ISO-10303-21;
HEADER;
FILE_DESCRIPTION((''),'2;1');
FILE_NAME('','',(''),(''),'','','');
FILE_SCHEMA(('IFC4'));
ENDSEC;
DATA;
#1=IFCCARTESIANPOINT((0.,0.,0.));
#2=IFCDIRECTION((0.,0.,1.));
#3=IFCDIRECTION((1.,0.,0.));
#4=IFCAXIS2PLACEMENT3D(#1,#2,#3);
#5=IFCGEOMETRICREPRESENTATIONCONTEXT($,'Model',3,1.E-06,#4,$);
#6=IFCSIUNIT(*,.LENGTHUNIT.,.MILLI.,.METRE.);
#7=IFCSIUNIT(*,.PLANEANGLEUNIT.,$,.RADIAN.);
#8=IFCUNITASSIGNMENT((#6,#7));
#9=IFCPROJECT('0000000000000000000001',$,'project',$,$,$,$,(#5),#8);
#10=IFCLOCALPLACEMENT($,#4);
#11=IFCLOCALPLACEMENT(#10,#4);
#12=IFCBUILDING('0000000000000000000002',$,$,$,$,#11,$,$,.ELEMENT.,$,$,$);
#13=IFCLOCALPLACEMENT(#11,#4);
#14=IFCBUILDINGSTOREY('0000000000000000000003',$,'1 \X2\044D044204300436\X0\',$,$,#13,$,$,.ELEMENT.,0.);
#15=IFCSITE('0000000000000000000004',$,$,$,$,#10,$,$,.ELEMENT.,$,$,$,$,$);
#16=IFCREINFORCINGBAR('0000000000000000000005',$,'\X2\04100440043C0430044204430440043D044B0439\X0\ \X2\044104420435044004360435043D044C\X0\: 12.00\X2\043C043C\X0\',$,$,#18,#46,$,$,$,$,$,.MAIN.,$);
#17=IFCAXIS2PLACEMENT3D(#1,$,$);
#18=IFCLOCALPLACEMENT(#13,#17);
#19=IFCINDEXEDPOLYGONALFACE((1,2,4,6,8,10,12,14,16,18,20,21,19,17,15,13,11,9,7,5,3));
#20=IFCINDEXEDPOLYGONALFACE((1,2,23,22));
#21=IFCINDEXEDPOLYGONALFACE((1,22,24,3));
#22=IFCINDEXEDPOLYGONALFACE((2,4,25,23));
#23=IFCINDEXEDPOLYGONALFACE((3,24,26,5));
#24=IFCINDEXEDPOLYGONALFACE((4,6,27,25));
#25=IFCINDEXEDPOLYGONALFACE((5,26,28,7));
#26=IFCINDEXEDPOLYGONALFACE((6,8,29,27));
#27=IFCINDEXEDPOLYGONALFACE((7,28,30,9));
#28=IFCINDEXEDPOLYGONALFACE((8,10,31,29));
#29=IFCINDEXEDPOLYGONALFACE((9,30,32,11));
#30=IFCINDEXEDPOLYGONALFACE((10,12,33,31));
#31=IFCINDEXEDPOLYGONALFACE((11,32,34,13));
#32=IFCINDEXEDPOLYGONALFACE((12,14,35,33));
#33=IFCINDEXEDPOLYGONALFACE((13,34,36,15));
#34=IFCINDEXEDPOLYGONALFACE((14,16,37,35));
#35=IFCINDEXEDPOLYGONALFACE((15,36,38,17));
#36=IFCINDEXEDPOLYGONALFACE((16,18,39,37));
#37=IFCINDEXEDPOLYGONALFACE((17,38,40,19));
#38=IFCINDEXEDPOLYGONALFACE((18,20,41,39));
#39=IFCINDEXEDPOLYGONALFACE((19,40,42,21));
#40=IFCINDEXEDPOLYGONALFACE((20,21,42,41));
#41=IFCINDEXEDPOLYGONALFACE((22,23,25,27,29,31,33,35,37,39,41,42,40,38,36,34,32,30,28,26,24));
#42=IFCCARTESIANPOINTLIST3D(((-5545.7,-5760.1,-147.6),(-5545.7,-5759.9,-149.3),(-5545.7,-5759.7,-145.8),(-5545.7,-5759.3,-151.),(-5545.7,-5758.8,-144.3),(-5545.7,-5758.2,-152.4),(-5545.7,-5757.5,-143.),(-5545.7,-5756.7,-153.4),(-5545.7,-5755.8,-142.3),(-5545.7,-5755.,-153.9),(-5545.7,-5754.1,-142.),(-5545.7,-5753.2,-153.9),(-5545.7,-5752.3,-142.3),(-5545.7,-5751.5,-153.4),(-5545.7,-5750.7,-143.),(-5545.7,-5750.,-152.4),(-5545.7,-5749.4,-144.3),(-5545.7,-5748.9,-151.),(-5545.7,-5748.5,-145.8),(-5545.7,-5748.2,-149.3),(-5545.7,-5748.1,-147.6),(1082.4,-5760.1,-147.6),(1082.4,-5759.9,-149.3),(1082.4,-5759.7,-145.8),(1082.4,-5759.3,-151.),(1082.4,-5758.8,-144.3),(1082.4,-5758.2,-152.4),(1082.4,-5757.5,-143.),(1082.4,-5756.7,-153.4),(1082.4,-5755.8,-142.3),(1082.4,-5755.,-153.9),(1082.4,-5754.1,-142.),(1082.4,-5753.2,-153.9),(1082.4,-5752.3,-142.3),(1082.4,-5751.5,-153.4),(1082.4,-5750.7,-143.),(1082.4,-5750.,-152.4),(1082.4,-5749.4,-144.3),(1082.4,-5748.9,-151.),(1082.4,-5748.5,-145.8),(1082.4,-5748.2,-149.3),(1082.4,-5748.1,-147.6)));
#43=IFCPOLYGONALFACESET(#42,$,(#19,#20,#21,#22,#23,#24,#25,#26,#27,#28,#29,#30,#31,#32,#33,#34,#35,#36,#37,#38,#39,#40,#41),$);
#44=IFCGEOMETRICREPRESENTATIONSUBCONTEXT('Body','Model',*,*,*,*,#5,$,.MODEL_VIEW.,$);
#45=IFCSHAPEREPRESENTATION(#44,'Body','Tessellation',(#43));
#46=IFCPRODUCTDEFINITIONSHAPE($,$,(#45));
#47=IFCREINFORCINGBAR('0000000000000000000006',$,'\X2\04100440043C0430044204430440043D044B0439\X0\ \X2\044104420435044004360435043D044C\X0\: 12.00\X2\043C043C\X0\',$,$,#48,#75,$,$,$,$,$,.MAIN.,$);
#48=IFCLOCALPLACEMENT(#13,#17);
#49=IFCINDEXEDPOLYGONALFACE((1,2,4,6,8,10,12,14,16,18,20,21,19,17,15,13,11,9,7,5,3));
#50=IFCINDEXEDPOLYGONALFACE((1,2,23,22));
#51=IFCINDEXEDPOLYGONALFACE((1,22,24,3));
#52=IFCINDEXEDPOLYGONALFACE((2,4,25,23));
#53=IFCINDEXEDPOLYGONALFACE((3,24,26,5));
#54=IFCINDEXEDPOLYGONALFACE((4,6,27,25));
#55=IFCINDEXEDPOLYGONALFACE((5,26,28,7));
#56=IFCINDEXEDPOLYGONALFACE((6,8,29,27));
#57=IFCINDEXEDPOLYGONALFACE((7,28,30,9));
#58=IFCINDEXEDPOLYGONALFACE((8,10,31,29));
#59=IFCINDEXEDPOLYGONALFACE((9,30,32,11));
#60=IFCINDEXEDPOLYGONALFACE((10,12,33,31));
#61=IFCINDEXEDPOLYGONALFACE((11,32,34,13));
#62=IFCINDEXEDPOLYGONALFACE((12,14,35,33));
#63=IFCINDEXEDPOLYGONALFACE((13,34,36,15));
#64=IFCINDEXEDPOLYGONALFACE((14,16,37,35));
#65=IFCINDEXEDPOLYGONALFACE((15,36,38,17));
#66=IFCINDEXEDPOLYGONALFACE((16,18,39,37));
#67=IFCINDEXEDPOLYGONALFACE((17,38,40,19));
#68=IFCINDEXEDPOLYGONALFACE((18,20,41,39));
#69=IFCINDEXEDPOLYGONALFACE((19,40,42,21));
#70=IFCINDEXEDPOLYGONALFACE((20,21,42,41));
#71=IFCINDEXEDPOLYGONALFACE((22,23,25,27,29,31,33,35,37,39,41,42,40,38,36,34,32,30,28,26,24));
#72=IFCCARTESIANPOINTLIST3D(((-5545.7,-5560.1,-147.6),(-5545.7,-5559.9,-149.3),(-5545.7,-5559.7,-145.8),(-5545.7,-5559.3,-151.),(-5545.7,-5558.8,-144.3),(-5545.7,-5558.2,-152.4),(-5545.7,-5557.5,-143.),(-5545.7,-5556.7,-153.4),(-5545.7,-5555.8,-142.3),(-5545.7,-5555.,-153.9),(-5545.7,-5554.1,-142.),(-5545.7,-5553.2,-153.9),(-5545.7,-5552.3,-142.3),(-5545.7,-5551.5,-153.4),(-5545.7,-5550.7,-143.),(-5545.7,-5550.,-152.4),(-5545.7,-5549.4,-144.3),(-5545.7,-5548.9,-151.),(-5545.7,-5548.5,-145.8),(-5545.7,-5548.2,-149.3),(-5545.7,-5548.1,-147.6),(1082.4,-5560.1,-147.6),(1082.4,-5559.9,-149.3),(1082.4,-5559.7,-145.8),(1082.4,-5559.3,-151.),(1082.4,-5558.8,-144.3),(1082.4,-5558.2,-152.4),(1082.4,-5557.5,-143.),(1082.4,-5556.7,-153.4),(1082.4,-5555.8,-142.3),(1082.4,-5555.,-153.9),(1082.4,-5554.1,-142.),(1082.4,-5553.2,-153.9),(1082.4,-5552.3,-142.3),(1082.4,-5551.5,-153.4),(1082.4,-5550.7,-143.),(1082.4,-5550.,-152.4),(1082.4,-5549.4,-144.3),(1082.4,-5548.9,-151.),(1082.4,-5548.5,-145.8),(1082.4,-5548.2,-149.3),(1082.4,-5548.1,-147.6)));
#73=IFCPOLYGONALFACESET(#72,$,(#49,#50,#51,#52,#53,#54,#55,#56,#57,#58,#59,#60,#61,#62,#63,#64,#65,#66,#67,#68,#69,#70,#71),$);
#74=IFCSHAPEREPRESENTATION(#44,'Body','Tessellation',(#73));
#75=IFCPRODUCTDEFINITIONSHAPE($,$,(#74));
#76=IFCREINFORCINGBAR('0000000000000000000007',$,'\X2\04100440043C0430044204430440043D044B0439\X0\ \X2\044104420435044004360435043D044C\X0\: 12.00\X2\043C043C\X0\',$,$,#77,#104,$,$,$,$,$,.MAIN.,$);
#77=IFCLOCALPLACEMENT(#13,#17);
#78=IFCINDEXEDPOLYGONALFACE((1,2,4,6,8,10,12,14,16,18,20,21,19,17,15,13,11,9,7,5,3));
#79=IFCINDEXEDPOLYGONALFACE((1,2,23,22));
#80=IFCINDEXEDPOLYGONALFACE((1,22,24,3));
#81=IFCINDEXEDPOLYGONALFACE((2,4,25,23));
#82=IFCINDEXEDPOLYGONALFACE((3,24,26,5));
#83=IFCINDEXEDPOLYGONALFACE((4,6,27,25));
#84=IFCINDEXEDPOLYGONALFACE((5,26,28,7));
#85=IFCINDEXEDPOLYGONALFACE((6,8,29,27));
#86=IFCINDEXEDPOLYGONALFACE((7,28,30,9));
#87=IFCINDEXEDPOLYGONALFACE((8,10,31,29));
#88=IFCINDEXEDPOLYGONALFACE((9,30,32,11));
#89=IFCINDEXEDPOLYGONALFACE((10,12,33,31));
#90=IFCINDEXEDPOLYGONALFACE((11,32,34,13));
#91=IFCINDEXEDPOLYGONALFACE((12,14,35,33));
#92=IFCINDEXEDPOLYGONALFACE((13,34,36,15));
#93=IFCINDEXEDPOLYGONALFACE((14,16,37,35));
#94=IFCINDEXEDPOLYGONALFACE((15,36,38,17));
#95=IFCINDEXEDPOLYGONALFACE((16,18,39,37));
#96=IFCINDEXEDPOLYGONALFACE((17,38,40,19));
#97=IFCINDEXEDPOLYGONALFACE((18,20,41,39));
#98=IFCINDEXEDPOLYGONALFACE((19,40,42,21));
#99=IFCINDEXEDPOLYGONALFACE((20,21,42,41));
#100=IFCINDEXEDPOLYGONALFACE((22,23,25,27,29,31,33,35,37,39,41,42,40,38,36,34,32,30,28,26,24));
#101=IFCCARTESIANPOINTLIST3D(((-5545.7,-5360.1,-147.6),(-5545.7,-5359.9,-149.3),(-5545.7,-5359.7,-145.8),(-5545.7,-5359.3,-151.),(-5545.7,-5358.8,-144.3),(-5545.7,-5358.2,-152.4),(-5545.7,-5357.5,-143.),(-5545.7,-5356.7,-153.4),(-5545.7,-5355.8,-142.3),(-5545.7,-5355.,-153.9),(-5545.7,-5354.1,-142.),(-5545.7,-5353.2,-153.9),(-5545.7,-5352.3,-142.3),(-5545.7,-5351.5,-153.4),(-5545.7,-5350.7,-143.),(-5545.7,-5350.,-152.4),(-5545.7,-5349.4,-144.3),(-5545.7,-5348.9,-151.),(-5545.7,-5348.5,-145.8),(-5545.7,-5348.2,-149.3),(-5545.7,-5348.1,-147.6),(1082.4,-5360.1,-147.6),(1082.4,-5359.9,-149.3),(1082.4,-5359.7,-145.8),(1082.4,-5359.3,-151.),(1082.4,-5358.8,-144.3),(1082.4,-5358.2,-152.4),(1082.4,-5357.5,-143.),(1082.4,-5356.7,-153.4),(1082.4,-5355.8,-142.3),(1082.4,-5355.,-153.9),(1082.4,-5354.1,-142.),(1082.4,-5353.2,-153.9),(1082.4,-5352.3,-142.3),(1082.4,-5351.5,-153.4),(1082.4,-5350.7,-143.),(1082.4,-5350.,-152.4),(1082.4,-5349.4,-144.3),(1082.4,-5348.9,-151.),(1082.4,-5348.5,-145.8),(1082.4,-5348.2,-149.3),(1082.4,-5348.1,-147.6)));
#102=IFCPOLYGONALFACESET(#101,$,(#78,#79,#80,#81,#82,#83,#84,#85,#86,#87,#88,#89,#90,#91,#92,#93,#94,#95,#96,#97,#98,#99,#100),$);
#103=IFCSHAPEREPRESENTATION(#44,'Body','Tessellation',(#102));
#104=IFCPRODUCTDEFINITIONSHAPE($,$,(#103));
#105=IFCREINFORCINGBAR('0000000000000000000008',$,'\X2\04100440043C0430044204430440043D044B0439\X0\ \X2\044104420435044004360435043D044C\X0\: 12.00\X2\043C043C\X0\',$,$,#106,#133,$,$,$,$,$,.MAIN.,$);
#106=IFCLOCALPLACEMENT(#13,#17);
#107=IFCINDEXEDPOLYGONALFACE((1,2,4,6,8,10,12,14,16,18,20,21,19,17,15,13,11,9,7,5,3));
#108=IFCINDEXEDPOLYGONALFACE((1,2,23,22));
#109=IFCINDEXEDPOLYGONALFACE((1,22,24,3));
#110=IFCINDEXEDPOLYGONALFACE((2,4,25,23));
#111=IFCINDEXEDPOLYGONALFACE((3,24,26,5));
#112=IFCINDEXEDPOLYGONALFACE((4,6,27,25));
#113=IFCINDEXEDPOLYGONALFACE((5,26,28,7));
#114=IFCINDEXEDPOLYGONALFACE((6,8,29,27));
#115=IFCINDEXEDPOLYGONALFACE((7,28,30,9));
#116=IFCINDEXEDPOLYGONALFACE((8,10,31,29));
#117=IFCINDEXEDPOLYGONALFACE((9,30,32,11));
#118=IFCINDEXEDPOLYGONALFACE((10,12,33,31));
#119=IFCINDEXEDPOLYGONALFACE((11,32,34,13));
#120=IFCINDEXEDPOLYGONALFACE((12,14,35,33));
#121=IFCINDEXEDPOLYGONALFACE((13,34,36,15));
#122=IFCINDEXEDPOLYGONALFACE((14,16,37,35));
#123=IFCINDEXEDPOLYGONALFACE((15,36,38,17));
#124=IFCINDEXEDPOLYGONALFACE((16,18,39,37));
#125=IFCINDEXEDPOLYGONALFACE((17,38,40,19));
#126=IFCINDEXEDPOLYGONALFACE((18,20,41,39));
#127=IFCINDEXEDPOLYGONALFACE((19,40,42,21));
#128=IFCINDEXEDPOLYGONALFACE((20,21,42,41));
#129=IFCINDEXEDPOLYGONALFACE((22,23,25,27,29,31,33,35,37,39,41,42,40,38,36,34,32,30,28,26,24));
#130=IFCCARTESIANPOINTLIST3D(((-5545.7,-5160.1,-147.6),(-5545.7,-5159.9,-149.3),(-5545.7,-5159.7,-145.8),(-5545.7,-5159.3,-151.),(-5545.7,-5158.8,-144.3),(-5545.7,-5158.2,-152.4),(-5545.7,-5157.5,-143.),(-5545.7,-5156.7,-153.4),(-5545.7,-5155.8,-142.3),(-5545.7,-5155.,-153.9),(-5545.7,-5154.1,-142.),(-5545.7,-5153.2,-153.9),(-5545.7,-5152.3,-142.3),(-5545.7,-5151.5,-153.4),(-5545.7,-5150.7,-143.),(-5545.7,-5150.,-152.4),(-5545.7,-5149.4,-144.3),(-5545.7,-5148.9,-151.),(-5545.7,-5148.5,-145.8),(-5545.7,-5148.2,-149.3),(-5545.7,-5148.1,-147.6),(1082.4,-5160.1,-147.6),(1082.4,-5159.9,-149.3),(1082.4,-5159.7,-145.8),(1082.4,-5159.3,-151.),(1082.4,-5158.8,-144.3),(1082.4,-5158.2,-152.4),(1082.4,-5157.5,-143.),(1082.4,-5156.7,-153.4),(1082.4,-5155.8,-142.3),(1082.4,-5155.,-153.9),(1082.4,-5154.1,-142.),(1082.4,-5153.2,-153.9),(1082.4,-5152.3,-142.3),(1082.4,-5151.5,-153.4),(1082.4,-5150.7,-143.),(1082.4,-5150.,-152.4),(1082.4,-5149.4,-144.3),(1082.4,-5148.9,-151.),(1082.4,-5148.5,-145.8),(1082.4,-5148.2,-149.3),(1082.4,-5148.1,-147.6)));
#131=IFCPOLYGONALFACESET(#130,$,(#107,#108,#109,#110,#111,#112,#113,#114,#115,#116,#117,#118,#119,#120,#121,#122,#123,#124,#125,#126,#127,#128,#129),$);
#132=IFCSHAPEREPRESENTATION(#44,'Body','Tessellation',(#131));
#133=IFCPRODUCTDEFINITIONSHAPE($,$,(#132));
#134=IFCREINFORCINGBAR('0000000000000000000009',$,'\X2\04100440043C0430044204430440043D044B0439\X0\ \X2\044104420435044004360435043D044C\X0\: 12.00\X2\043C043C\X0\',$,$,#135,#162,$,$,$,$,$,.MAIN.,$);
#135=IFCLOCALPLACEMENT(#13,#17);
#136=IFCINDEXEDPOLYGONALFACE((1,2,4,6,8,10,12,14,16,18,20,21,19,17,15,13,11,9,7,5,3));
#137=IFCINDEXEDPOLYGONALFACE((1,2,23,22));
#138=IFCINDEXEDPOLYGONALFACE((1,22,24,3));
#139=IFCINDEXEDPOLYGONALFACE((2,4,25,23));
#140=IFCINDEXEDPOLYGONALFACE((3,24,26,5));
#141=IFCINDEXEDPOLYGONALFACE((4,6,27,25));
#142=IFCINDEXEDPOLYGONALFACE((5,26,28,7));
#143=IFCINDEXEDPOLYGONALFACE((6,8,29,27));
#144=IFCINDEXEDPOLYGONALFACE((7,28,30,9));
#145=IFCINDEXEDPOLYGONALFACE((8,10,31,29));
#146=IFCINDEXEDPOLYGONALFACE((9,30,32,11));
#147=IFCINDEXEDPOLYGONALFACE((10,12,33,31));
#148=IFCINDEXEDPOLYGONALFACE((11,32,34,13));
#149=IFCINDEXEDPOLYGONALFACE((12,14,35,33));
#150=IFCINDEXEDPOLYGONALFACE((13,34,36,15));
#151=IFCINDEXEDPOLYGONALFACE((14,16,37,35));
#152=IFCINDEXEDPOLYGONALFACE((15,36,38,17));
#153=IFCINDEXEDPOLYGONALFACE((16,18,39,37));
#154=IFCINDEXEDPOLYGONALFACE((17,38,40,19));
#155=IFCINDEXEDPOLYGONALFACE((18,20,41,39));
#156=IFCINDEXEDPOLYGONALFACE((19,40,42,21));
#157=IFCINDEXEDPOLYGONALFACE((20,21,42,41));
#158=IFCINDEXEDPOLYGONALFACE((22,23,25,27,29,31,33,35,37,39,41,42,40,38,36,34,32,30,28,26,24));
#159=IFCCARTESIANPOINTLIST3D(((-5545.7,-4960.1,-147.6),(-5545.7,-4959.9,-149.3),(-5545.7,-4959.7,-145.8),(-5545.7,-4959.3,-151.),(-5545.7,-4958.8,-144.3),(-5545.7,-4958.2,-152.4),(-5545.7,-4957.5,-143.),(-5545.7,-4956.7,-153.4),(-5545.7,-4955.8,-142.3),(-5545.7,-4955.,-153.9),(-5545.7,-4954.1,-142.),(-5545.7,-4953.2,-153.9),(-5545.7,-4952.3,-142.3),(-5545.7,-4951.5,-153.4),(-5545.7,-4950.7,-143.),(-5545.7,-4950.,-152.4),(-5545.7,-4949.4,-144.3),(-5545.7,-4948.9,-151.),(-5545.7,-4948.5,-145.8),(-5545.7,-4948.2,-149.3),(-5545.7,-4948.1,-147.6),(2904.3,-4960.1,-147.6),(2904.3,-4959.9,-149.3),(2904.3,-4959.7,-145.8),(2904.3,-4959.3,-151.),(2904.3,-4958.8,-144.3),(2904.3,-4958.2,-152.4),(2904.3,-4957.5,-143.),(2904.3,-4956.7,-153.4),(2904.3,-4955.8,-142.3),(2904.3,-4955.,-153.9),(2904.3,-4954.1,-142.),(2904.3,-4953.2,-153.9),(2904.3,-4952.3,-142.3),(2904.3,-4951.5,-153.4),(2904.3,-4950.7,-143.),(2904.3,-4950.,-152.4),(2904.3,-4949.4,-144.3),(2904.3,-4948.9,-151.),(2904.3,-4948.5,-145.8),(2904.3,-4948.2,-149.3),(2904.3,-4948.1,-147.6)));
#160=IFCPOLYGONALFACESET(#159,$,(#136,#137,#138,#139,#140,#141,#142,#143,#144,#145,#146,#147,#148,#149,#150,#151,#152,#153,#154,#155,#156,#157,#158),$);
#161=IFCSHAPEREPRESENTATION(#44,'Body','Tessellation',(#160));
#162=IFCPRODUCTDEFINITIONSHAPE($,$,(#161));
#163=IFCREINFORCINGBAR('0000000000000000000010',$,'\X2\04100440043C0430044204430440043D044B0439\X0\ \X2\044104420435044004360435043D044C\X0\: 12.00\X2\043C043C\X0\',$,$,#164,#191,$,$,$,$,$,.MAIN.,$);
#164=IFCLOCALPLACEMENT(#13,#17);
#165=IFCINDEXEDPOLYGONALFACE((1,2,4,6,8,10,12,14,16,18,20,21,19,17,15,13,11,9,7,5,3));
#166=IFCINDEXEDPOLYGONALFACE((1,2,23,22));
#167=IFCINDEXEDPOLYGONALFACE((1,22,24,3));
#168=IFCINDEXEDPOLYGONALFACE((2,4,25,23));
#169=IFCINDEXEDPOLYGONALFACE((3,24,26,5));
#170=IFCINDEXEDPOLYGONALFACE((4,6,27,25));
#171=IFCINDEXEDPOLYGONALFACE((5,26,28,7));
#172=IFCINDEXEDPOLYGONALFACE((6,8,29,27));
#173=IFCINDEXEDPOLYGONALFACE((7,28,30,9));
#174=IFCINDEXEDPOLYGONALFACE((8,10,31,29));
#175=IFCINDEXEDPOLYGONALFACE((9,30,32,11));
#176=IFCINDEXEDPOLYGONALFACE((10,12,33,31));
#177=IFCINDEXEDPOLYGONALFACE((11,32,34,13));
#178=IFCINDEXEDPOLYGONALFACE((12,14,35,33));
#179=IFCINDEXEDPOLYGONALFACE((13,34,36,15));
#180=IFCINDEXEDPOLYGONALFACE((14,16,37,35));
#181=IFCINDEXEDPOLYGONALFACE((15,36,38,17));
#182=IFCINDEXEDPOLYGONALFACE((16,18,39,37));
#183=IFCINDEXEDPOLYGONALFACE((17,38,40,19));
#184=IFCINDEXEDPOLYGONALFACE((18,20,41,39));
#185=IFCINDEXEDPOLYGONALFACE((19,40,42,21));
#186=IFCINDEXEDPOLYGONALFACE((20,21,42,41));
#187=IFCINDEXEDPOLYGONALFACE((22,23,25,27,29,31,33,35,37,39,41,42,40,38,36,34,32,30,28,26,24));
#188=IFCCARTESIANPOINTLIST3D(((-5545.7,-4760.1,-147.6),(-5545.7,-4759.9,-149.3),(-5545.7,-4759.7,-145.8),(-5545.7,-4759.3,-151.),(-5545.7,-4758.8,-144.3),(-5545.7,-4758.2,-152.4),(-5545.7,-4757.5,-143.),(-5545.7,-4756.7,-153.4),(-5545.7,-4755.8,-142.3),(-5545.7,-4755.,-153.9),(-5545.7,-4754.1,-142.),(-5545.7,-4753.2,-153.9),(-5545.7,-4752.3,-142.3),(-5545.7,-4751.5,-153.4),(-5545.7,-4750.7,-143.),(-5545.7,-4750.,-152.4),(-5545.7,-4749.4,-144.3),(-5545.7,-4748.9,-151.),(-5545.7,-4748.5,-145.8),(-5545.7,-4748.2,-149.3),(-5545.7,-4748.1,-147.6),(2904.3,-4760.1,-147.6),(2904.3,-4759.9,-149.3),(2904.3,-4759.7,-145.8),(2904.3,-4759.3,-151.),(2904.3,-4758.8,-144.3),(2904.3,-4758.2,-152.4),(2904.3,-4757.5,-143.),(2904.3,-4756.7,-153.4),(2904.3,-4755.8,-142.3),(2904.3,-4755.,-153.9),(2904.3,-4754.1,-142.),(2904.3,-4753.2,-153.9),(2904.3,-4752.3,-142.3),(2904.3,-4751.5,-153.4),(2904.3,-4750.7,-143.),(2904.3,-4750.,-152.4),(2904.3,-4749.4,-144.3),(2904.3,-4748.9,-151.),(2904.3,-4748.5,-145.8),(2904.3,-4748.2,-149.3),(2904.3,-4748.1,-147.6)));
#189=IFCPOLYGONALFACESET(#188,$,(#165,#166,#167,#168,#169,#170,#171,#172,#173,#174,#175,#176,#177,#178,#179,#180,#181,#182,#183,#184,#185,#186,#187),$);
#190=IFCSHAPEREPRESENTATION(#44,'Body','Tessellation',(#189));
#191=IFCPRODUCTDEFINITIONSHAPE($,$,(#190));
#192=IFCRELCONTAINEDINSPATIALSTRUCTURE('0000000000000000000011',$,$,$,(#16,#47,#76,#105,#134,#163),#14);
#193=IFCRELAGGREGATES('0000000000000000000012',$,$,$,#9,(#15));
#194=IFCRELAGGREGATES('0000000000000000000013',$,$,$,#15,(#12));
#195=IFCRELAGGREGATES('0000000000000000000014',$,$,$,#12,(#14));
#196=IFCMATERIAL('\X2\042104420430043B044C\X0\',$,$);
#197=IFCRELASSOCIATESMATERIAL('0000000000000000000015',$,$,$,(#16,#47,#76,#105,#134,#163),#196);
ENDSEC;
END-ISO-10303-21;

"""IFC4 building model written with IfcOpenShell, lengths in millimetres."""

from ifc_helpers import new_model, entity, si_unit, origin_with_axes, place, context, subcontext, project, spatial, source, transform, mapped, material, element, save


model = new_model("IFC4")

# Units and contexts
model_context = context("Model", 3, precision=1e-06, world=origin_with_axes())
body_context = subcontext(model_context, "Body", "Model", "MODEL_VIEW")
ifc_project = project(units=[si_unit("LENGTHUNIT", "METRE", prefix="MILLI"), si_unit("PLANEANGLEUNIT", "RADIAN")], contexts=[model_context])

# Site, building, storey
site_placement = place(None, origin_with_axes())
site = spatial("IfcSite", under=ifc_project, at=site_placement, CompositionType="ELEMENT")
building_placement = place(site_placement, origin_with_axes())
building = spatial("IfcBuilding", under=site, at=building_placement, CompositionType="ELEMENT")
storey_placement = place(building_placement, origin_with_axes())
storey = spatial("IfcBuildingStorey", under=building, at=storey_placement, Name="1 этаж", CompositionType="ELEMENT", Elevation=0.0)

# Shared definitions
ifc_material_1 = material(Name="Сталь")

# Reinforcing bars
shared_shape_1 = source(origin_with_axes(), body_context, "Body", "AdvancedSweptSolid", [
    entity("IfcSweptDiskSolid", entity("IfcIndexedPolyCurve", entity("IfcCartesianPointList3D", [[0.0, 0.0, 0.0], [6628.1, 0.0, 0.0]]), [entity("IfcLineIndex", [1, 2])]), 6.0),
])
reinforcing_bar_1_placement = place(storey_placement, origin_with_axes())
element("IfcReinforcingBar", 1, at=reinforcing_bar_1_placement, inside=storey, material=ifc_material_1, Name="Арматурный стержень: 12.00мм", PredefinedType="MAIN", context=body_context, shape_type="MappedRepresentation", body=[
    mapped(shared_shape_1, transform((-5545.7, -5754.1, -148.0), x_axis=(1.0, 0.0, 0.0), y_axis=(0.0, 1.0, 0.0), z_axis=(0.0, 0.0, 1.0), scale=1.0)),
])
reinforcing_bar_2_placement = place(storey_placement, origin_with_axes())
element("IfcReinforcingBar", 2, at=reinforcing_bar_2_placement, inside=storey, material=ifc_material_1, Name="Арматурный стержень: 12.00мм", PredefinedType="MAIN", context=body_context, shape_type="MappedRepresentation", body=[
    mapped(shared_shape_1, transform((-5545.7, -5554.1, -148.0), x_axis=(1.0, 0.0, 0.0), y_axis=(0.0, 1.0, 0.0), z_axis=(0.0, 0.0, 1.0), scale=1.0)),
])
reinforcing_bar_3_placement = place(storey_placement, origin_with_axes())
element("IfcReinforcingBar", 3, at=reinforcing_bar_3_placement, inside=storey, material=ifc_material_1, Name="Арматурный стержень: 12.00мм", PredefinedType="MAIN", context=body_context, shape_type="MappedRepresentation", body=[
    mapped(shared_shape_1, transform((-5545.7, -5354.1, -148.0), x_axis=(1.0, 0.0, 0.0), y_axis=(0.0, 1.0, 0.0), z_axis=(0.0, 0.0, 1.0), scale=1.0)),
])
reinforcing_bar_4_placement = place(storey_placement, origin_with_axes())
element("IfcReinforcingBar", 4, at=reinforcing_bar_4_placement, inside=storey, material=ifc_material_1, Name="Арматурный стержень: 12.00мм", PredefinedType="MAIN", context=body_context, shape_type="MappedRepresentation", body=[
    mapped(shared_shape_1, transform((-5545.7, -5154.1, -148.0), x_axis=(1.0, 0.0, 0.0), y_axis=(0.0, 1.0, 0.0), z_axis=(0.0, 0.0, 1.0), scale=1.0)),
])
shared_shape_2 = source(origin_with_axes(), body_context, "Body", "AdvancedSweptSolid", [
    entity("IfcSweptDiskSolid", entity("IfcIndexedPolyCurve", entity("IfcCartesianPointList3D", [[0.0, 0.0, 0.0], [8450.0, 0.0, 0.0]]), [entity("IfcLineIndex", [1, 2])]), 6.0),
])
reinforcing_bar_5_placement = place(storey_placement, origin_with_axes())
element("IfcReinforcingBar", 5, at=reinforcing_bar_5_placement, inside=storey, material=ifc_material_1, Name="Арматурный стержень: 12.00мм", PredefinedType="MAIN", context=body_context, shape_type="MappedRepresentation", body=[
    mapped(shared_shape_2, transform((-5545.7, -4954.1, -148.0), x_axis=(1.0, 0.0, 0.0), y_axis=(0.0, 1.0, 0.0), z_axis=(0.0, 0.0, 1.0), scale=1.0)),
])
reinforcing_bar_6_placement = place(storey_placement, origin_with_axes())
element("IfcReinforcingBar", 6, at=reinforcing_bar_6_placement, inside=storey, material=ifc_material_1, Name="Арматурный стержень: 12.00мм", PredefinedType="MAIN", context=body_context, shape_type="MappedRepresentation", body=[
    mapped(shared_shape_2, transform((-5545.7, -4754.1, -148.0), x_axis=(1.0, 0.0, 0.0), y_axis=(0.0, 1.0, 0.0), z_axis=(0.0, 0.0, 1.0), scale=1.0)),
])

save(model, "model.ifc")
